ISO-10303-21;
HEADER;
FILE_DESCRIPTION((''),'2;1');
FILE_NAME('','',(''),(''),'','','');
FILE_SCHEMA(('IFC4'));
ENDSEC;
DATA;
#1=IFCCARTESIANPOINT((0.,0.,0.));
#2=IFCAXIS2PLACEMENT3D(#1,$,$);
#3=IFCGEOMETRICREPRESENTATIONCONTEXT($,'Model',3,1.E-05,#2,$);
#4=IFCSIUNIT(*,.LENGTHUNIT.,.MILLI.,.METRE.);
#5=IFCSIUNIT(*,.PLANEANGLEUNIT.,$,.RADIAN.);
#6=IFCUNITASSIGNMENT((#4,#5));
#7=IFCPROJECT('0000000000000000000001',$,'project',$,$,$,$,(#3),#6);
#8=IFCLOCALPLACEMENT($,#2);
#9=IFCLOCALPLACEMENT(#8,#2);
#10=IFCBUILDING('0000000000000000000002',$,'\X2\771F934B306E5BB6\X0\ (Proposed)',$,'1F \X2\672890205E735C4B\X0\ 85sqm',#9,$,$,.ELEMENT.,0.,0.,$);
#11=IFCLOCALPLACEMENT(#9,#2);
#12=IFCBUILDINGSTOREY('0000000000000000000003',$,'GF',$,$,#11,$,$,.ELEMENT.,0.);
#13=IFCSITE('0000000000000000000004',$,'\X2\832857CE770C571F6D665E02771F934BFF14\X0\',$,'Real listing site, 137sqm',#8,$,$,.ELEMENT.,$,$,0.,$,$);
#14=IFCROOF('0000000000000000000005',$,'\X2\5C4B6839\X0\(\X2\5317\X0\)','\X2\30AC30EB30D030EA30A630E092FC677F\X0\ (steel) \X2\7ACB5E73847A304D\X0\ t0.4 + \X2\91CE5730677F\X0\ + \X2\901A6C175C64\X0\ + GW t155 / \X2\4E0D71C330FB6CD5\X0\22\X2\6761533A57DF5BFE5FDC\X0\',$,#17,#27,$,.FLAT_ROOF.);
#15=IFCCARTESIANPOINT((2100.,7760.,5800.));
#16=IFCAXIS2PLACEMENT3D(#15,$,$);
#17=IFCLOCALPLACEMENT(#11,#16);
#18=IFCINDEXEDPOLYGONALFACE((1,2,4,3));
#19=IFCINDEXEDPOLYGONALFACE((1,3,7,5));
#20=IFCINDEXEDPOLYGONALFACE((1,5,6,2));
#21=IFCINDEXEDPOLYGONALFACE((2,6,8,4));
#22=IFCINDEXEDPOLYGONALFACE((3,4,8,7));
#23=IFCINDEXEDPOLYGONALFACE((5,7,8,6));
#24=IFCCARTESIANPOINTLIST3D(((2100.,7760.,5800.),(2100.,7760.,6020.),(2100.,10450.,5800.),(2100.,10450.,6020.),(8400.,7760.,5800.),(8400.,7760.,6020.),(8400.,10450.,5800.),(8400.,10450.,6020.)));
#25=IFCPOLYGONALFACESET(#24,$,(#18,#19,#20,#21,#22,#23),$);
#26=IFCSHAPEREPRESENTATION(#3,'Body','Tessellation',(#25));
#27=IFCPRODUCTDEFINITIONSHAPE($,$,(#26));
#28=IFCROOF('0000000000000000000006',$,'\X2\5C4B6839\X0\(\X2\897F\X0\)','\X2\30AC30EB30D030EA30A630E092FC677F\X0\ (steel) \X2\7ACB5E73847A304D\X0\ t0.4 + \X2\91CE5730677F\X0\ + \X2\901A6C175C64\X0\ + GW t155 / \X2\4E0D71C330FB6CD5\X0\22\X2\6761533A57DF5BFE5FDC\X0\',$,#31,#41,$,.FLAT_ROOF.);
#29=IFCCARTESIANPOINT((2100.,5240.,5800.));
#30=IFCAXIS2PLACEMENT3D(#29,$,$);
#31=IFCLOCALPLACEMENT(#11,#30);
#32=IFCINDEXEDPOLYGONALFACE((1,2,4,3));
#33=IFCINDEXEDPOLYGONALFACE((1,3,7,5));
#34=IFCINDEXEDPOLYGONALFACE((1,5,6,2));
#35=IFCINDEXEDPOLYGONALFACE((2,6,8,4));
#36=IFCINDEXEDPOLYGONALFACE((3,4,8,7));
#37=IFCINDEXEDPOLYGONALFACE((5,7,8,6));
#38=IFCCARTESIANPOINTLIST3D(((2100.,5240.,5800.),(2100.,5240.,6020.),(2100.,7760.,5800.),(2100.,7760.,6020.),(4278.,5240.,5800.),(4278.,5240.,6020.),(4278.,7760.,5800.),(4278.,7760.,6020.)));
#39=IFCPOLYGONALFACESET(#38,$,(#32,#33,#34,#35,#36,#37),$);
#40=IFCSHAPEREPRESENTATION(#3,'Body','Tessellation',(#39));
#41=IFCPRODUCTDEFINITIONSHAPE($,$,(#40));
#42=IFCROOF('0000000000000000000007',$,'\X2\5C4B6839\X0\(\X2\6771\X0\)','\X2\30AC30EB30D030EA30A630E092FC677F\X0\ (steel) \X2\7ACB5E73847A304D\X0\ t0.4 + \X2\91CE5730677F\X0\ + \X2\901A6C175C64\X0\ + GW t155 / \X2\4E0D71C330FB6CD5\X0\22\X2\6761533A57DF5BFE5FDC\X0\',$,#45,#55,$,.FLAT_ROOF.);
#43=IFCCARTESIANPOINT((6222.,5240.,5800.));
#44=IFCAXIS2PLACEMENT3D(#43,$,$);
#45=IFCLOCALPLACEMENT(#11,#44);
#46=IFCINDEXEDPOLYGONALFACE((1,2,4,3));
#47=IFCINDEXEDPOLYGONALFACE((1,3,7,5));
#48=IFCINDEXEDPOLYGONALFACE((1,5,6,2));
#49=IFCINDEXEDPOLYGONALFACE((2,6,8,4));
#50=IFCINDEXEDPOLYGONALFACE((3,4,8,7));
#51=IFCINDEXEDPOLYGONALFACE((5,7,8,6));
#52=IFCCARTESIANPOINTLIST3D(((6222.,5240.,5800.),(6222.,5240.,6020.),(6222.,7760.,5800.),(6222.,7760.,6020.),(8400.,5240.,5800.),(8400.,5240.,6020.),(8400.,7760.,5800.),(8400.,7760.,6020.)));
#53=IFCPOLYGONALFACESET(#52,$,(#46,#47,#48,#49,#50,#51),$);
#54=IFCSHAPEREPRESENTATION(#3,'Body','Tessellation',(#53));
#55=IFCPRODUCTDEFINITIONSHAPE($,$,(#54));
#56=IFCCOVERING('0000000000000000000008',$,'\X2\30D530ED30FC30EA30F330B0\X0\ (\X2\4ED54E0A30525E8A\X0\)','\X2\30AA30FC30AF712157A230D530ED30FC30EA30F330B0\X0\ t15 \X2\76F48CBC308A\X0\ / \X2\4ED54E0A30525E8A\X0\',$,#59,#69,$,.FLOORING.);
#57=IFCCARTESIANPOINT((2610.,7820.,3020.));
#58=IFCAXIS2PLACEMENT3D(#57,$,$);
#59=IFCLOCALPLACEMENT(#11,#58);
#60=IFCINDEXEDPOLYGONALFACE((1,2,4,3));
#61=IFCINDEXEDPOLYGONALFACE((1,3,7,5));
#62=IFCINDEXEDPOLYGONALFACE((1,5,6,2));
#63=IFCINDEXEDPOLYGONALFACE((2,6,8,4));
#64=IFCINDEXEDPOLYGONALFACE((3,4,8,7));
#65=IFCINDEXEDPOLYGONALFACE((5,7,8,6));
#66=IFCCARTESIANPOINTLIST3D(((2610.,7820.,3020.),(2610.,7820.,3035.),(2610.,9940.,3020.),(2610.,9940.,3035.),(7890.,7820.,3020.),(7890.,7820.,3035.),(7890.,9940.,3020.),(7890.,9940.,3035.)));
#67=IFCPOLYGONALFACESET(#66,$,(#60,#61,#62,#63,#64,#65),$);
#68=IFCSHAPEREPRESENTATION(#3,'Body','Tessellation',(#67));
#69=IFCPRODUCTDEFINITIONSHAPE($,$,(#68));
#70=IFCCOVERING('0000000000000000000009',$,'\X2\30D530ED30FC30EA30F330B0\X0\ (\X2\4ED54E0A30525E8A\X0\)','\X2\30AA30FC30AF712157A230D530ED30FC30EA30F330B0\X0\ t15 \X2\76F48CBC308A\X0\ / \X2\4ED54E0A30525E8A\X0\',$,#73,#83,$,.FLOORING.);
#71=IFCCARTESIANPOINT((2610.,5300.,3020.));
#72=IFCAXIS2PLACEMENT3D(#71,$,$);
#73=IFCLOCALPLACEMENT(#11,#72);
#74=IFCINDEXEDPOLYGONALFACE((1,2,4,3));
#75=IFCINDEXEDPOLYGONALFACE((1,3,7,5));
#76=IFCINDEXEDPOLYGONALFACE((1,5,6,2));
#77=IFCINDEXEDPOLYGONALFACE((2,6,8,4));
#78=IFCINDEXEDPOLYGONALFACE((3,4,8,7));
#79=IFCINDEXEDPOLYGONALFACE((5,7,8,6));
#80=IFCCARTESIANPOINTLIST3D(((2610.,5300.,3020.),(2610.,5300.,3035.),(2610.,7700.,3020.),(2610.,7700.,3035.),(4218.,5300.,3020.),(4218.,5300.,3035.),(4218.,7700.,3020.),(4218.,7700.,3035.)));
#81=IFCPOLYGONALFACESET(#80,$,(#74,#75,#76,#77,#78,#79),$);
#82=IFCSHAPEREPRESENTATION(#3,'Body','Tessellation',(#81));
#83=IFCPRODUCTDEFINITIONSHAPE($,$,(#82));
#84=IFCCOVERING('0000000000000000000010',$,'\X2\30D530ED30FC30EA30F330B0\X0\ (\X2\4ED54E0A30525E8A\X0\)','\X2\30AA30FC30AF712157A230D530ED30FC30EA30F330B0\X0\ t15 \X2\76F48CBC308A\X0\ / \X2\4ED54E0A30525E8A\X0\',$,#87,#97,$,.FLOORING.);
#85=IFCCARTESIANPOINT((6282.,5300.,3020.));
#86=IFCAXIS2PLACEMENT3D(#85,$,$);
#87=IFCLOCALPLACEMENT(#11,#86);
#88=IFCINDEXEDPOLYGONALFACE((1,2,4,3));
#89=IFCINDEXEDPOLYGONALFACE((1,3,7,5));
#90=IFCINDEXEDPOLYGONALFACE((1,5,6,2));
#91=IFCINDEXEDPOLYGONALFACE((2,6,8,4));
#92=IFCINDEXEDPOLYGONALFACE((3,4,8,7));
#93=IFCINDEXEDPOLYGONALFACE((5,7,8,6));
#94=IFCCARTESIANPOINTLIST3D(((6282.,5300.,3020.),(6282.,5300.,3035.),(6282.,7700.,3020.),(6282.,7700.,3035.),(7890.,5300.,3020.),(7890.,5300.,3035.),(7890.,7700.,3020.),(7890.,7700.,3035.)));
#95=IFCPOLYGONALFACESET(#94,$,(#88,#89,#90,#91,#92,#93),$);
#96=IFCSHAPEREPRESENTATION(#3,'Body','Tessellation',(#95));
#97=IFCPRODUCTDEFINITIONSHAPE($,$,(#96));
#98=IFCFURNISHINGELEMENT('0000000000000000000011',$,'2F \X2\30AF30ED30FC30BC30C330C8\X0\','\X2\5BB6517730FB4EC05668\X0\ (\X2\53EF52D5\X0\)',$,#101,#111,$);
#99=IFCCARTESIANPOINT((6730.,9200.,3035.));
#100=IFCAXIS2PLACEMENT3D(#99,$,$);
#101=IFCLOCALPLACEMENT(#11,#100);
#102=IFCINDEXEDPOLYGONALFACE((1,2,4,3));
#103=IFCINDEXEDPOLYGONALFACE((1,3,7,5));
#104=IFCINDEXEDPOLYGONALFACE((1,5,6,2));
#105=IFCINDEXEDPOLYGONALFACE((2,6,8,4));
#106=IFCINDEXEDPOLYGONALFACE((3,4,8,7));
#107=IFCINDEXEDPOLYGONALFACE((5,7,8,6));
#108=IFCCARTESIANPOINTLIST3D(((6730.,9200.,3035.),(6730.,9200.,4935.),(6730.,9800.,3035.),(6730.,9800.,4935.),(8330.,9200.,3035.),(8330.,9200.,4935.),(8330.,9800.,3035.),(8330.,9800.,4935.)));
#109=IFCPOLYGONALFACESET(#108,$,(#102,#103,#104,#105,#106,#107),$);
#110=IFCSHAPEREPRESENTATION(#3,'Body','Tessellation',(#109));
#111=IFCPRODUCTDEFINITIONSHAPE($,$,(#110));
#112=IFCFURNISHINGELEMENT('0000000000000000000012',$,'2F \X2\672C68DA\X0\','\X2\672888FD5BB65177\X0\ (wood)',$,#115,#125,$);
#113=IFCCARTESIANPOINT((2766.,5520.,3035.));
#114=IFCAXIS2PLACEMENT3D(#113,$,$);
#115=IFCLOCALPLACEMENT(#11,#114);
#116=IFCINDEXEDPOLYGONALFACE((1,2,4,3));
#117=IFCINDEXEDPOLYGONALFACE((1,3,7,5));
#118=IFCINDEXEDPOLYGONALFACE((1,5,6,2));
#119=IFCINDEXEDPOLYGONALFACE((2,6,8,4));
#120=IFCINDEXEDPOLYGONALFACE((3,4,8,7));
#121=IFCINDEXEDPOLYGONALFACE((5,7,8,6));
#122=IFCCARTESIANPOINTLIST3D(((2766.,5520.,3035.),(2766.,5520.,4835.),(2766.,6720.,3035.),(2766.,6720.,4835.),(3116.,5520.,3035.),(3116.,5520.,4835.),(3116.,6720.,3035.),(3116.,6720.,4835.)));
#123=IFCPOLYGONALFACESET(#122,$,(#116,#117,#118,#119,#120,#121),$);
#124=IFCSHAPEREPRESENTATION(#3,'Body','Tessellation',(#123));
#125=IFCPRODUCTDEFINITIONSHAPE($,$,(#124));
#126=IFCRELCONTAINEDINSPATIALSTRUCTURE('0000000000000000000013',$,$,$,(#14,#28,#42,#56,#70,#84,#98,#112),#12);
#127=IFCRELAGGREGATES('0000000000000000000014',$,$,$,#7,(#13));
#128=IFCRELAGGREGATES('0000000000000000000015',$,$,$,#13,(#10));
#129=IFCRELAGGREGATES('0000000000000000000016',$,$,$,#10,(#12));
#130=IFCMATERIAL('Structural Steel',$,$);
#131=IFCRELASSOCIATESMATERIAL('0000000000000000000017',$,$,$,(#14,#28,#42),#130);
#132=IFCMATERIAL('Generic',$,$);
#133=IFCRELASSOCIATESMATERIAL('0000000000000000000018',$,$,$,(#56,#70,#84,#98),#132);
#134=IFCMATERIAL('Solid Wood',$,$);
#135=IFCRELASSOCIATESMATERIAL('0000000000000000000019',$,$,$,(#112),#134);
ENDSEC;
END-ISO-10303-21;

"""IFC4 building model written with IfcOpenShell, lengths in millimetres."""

from ifc_helpers import new_model, si_unit, frame, frame_2d, origin, place, context, project, spatial, rectangle, extrude, material, element, save


model = new_model("IFC4")

# Units and contexts
model_context = context("Model", 3, precision=1e-05, world=origin())
ifc_project = project(units=[si_unit("LENGTHUNIT", "METRE", prefix="MILLI"), si_unit("PLANEANGLEUNIT", "RADIAN")], contexts=[model_context])

# Site, building, storey
site_placement = place(None, origin())
site = spatial("IfcSite", under=ifc_project, at=site_placement, Name="茨城県土浦市真鍋４", ObjectType="Real listing site, 137sqm", CompositionType="ELEMENT", RefElevation=0.0)
building_placement = place(site_placement, origin())
building = spatial("IfcBuilding", under=site, at=building_placement, Name="真鍋の家 (Proposed)", ObjectType="1F 木造平屋 85sqm", CompositionType="ELEMENT", ElevationOfRefHeight=0.0, ElevationOfTerrain=0.0)
storey_placement = place(building_placement, origin())
storey = spatial("IfcBuildingStorey", under=building, at=storey_placement, Name="GF", CompositionType="ELEMENT", Elevation=0.0)

# Shared definitions
ifc_material_1 = material(Name="Solid Wood")

# Shared definitions
ifc_material_2 = material(Name="Generic")

# Roofs
ifc_material_3 = material(Name="Structural Steel")
for number, where, name in (
    (1, (2100.0, 7760.0, 5800.0), "屋根(北)"),
):
    element("IfcRoof", number, at=place(storey_placement, frame(where)), inside=storey, material=ifc_material_3, Name=name, Description="ガルバリウム鋼板 (steel) 立平葺き t0.4 + 野地板 + 通気層 + GW t155 / 不燃・法22条区域対応", PredefinedType="FLAT_ROOF", context=model_context, shape_type="SweptSolid", body=[
        extrude(rectangle(XDim=6300.0, YDim=2690.0, at=frame_2d((3150.0, 1345.0))), frame((2100.0, 7760.0, 5800.0)), (0.0, 0.0, 1.0), 220.0),
    ])
roof_1_placement = place(storey_placement, frame((2100.0, 5240.0, 5800.0)))
element("IfcRoof", 2, at=roof_1_placement, inside=storey, material=ifc_material_3, Name="屋根(西)", Description="ガルバリウム鋼板 (steel) 立平葺き t0.4 + 野地板 + 通気層 + GW t155 / 不燃・法22条区域対応", PredefinedType="FLAT_ROOF", context=model_context, shape_type="SweptSolid", body=[
    extrude(rectangle(XDim=2178.0, YDim=2520.0, at=frame_2d((1089.0, 1260.0))), frame((2100.0, 5240.0, 5800.0)), (0.0, 0.0, 1.0), 220.0),
])
roof_2_placement = place(storey_placement, frame((6222.0, 5240.0, 5800.0)))
element("IfcRoof", 3, at=roof_2_placement, inside=storey, material=ifc_material_3, Name="屋根(東)", Description="ガルバリウム鋼板 (steel) 立平葺き t0.4 + 野地板 + 通気層 + GW t155 / 不燃・法22条区域対応", PredefinedType="FLAT_ROOF", context=model_context, shape_type="SweptSolid", body=[
    extrude(rectangle(XDim=2178.0, YDim=2520.0, at=frame_2d((1089.0, 1260.0))), frame((6222.0, 5240.0, 5800.0)), (0.0, 0.0, 1.0), 220.0),
])

# Coverings
covering_1_placement = place(storey_placement, frame((2610.0, 7820.0, 3020.0)))
element("IfcCovering", 4, at=covering_1_placement, inside=storey, material=ifc_material_2, Name="フローリング (仕上げ床)", Description="オーク無垢フローリング t15 直貼り / 仕上げ床", PredefinedType="FLOORING", context=model_context, shape_type="SweptSolid", body=[
    extrude(rectangle(XDim=5280.0, YDim=2120.0, at=frame_2d((2640.0, 1060.0))), frame((2610.0, 7820.0, 3020.0)), (0.0, 0.0, 1.0), 15.0),
])
covering_2_placement = place(storey_placement, frame((2610.0, 5300.0, 3020.0)))
element("IfcCovering", 5, at=covering_2_placement, inside=storey, material=ifc_material_2, Name="フローリング (仕上げ床)", Description="オーク無垢フローリング t15 直貼り / 仕上げ床", PredefinedType="FLOORING", context=model_context, shape_type="SweptSolid", body=[
    extrude(rectangle(XDim=1608.0, YDim=2400.0, at=frame_2d((804.0, 1200.0))), frame((2610.0, 5300.0, 3020.0)), (0.0, 0.0, 1.0), 15.0),
])
covering_3_placement = place(storey_placement, frame((6282.0, 5300.0, 3020.0)))
element("IfcCovering", 6, at=covering_3_placement, inside=storey, material=ifc_material_2, Name="フローリング (仕上げ床)", Description="オーク無垢フローリング t15 直貼り / 仕上げ床", PredefinedType="FLOORING", context=model_context, shape_type="SweptSolid", body=[
    extrude(rectangle(XDim=1608.0, YDim=2400.0, at=frame_2d((804.0, 1200.0))), frame((6282.0, 5300.0, 3020.0)), (0.0, 0.0, 1.0), 15.0),
])

# Furnishing elements
furnishing_1_placement = place(storey_placement, frame((6730.0, 9200.0, 3035.0)))
element("IfcFurnishingElement", 7, at=furnishing_1_placement, inside=storey, material=ifc_material_2, Name="2F クローゼット", Description="家具・什器 (可動)", context=model_context, shape_type="SweptSolid", body=[
    extrude(rectangle(XDim=1600.0, YDim=600.0, at=frame_2d((800.0, 300.0))), frame((6730.0, 9200.0, 3035.0)), (0.0, 0.0, 1.0), 1900.0),
])
furnishing_2_placement = place(storey_placement, frame((2766.0, 5520.0, 3035.0)))
element("IfcFurnishingElement", 8, at=furnishing_2_placement, inside=storey, material=ifc_material_1, Name="2F 本棚", Description="木製家具 (wood)", context=model_context, shape_type="SweptSolid", body=[
    extrude(rectangle(XDim=350.0, YDim=1200.0, at=frame_2d((175.0, 600.0))), frame((2766.0, 5520.0, 3035.0)), (0.0, 0.0, 1.0), 1800.0),
])

save(model, "model.ifc")
